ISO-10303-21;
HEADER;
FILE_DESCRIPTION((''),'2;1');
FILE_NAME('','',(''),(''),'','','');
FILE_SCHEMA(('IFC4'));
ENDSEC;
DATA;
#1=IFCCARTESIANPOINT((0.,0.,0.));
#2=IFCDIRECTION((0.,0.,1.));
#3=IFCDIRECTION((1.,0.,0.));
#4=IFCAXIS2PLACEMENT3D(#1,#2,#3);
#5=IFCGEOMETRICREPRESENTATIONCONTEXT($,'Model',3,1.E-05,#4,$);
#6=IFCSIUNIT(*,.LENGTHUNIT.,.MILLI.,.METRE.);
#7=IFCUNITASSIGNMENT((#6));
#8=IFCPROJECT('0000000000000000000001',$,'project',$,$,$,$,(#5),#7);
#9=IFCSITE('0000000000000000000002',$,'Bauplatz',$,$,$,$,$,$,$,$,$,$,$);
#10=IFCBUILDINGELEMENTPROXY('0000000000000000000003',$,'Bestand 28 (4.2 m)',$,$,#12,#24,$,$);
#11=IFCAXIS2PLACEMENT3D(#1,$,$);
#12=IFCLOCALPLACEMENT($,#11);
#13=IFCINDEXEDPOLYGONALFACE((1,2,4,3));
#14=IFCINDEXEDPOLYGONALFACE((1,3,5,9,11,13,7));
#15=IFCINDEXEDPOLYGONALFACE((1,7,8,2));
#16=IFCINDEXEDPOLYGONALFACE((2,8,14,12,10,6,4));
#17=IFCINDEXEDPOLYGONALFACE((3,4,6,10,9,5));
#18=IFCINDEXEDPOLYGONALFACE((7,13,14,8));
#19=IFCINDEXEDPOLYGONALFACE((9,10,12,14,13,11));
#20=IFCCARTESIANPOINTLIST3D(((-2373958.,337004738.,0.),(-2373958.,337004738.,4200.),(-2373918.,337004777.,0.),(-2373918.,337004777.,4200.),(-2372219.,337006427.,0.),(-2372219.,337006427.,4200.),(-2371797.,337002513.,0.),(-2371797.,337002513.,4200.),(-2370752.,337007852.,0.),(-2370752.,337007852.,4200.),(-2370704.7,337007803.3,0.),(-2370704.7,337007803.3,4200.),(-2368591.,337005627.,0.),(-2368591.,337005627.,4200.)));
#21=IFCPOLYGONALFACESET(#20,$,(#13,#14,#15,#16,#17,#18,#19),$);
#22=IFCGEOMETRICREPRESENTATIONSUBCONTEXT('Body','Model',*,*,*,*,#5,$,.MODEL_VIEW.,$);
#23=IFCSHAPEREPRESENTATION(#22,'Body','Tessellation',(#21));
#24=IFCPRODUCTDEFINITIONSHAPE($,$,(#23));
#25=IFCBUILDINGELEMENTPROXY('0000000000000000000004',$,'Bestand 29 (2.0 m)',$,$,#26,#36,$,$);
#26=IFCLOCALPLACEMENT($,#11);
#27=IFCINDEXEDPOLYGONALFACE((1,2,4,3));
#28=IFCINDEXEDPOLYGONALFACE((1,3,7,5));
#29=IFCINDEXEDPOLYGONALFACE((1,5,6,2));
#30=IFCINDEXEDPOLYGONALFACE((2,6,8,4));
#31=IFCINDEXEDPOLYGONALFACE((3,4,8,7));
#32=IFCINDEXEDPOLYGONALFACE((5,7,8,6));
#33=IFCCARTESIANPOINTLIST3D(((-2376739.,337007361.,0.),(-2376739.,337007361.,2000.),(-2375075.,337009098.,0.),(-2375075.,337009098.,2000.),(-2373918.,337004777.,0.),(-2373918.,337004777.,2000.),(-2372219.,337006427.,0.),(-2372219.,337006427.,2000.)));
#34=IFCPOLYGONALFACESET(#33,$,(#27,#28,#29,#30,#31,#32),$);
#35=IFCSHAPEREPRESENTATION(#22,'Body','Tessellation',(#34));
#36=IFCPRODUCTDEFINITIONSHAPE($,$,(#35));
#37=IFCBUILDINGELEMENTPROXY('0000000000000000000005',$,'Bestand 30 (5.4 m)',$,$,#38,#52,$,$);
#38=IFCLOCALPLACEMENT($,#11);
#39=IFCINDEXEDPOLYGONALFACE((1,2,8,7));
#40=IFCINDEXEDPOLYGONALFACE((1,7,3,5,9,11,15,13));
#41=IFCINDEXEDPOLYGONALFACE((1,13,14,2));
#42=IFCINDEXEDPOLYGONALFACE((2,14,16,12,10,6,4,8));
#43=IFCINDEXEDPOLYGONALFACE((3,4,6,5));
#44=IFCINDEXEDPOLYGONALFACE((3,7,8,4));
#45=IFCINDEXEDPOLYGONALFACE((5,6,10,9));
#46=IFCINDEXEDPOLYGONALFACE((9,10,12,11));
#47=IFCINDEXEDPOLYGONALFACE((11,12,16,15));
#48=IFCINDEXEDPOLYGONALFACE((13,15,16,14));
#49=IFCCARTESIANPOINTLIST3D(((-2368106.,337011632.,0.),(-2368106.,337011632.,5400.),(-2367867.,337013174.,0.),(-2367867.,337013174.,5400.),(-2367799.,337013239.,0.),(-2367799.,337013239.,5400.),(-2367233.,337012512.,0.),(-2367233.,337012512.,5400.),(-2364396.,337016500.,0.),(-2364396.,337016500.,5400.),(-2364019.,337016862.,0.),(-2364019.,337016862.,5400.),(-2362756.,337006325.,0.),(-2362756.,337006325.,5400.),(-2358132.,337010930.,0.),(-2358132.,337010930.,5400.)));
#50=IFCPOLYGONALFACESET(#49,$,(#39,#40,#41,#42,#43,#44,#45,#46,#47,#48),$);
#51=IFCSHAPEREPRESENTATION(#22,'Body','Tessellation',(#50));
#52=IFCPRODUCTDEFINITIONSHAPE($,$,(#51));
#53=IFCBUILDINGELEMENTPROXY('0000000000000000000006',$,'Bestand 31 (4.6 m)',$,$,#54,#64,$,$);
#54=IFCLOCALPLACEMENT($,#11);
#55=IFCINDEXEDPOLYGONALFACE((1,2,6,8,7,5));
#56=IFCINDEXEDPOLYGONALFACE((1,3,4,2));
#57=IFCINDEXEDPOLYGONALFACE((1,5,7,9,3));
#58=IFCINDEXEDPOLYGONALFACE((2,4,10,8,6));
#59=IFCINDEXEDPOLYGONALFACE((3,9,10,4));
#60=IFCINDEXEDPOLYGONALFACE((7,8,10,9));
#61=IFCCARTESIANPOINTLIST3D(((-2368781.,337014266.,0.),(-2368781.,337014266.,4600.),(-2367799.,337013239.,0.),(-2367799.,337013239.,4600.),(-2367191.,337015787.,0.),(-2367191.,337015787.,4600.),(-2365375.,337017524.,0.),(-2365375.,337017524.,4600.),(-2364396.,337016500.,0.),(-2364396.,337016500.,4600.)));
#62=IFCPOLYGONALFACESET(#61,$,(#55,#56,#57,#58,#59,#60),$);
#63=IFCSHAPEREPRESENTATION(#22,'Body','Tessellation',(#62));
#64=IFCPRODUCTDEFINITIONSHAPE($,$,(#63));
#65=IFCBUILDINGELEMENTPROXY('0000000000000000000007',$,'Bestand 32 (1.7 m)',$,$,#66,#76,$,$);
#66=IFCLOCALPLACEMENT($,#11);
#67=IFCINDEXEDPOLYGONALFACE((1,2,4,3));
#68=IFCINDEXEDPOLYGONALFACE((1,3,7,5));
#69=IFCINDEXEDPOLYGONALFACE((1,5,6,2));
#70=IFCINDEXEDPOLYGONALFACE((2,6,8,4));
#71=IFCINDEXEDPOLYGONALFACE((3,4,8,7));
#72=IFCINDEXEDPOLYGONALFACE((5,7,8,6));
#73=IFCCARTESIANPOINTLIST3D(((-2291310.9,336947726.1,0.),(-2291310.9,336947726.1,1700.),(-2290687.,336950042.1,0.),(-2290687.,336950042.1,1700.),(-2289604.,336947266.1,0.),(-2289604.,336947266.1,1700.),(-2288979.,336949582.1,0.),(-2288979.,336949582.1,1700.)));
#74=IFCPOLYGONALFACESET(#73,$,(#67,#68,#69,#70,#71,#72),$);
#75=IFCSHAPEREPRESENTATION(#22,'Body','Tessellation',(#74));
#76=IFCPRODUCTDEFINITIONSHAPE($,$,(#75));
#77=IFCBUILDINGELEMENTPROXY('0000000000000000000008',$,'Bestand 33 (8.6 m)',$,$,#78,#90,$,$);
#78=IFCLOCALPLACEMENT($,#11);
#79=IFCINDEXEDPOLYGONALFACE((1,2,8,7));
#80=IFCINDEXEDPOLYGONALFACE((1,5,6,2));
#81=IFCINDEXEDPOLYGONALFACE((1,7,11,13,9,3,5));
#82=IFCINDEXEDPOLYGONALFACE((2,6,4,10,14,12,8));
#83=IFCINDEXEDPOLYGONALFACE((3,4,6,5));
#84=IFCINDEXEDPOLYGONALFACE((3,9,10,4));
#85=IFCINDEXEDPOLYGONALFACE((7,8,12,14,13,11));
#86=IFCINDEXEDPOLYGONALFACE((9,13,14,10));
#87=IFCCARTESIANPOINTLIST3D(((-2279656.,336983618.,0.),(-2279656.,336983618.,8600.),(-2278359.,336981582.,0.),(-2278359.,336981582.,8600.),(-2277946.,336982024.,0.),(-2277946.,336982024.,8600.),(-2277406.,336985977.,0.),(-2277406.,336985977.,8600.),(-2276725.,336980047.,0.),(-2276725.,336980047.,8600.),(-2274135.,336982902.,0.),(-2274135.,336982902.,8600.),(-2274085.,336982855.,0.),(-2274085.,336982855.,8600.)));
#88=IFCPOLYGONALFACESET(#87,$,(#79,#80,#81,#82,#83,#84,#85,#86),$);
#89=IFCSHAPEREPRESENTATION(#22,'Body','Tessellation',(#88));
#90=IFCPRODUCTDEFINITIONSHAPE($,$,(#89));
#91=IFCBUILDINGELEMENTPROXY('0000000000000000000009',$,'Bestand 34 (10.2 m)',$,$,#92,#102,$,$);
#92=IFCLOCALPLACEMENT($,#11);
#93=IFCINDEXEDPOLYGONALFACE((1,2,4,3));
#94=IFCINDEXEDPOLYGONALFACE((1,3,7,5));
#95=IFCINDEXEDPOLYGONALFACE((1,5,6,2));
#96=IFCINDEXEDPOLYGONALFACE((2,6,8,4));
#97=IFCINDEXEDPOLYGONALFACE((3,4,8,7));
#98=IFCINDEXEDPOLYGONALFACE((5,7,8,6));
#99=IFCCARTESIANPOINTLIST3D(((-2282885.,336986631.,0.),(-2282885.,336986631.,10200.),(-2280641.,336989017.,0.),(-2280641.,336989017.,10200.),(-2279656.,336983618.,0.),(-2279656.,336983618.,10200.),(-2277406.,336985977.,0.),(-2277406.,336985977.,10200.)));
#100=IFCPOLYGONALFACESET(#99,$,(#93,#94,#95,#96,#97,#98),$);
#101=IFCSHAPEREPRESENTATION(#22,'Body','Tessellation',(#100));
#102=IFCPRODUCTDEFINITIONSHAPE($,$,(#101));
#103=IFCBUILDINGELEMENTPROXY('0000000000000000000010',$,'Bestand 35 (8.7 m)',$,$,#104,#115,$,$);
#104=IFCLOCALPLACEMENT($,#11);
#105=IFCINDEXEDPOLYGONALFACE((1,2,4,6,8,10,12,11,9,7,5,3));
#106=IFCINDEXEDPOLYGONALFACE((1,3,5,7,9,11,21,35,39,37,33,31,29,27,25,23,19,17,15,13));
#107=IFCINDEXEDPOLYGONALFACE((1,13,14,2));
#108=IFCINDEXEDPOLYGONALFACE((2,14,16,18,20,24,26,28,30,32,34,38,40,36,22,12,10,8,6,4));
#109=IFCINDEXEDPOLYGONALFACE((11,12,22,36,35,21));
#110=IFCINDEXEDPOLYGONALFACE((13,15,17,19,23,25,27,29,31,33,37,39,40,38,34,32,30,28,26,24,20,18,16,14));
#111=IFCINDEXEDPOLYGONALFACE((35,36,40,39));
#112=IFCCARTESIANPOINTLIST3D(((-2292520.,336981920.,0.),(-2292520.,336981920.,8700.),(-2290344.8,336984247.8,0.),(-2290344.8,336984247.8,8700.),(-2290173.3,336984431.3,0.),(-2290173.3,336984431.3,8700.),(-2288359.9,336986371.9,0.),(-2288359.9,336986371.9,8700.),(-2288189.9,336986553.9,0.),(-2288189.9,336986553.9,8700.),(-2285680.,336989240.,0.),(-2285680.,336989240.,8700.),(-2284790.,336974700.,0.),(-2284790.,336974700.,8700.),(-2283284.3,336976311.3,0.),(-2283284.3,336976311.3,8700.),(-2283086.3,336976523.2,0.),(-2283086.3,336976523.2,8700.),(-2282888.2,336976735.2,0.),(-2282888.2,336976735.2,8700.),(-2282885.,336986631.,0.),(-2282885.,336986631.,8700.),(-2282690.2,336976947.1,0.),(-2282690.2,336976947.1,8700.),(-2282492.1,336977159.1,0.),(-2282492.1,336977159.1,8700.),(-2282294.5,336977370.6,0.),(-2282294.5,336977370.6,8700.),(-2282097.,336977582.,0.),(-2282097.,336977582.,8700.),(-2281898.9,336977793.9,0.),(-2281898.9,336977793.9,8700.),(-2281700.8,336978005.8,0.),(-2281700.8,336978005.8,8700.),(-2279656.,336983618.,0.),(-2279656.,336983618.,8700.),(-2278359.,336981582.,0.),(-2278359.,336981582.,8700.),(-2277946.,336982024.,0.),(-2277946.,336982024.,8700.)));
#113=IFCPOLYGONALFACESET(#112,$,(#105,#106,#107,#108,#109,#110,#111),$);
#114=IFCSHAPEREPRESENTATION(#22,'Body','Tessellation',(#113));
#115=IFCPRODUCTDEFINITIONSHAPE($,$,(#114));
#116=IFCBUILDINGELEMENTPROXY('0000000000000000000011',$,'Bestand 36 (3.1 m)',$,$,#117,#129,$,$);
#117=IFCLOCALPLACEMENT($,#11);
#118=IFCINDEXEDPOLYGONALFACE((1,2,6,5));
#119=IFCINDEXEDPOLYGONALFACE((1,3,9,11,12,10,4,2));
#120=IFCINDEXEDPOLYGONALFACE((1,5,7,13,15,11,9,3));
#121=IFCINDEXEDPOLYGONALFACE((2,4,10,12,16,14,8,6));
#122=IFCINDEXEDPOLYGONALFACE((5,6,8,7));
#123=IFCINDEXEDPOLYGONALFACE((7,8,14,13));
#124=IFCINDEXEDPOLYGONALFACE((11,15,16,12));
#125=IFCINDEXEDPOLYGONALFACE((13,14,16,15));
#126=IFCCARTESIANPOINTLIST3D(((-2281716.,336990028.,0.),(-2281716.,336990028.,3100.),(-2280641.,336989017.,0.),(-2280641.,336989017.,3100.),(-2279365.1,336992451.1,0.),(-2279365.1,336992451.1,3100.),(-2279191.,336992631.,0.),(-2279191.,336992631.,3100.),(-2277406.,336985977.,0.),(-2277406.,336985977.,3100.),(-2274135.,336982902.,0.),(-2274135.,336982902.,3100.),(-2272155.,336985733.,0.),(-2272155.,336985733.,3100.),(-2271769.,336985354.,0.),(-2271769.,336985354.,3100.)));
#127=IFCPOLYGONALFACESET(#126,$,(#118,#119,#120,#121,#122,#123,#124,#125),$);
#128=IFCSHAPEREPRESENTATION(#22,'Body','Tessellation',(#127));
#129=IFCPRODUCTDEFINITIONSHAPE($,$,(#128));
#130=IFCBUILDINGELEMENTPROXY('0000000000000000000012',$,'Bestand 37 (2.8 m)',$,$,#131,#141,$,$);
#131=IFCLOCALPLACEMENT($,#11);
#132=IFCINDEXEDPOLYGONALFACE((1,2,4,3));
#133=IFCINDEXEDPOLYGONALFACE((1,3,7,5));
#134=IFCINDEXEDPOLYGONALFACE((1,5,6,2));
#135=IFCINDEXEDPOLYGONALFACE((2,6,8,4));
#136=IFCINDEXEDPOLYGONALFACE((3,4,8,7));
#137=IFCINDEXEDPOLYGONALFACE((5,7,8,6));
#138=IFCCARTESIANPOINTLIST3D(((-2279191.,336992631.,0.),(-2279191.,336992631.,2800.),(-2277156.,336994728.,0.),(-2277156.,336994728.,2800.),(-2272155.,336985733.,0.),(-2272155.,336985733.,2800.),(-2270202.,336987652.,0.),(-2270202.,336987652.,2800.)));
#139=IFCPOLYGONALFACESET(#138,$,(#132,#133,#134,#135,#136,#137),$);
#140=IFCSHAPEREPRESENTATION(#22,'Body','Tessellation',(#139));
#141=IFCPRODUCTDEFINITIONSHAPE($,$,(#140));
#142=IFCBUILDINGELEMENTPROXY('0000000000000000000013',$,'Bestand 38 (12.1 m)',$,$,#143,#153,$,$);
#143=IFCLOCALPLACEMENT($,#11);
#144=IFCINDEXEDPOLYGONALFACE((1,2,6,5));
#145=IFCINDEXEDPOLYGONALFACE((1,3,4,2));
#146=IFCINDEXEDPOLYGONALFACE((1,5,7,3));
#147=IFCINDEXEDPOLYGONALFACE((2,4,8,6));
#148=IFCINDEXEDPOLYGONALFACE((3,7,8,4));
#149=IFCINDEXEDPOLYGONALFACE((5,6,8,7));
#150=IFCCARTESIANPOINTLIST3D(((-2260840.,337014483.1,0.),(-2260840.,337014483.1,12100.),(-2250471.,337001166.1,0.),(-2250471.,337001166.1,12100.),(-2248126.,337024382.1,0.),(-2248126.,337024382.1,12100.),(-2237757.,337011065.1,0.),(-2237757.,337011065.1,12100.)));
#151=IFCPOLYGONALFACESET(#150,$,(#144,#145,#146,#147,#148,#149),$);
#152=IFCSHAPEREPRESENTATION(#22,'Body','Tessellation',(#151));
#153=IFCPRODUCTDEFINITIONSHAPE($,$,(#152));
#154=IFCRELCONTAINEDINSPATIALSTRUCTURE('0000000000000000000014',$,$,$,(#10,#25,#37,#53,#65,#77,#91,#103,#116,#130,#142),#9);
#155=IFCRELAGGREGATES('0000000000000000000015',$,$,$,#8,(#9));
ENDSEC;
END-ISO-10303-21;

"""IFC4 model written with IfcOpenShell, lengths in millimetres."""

from ifc_helpers import new_model, si_unit, origin_with_axes, place, context, subcontext, project, spatial, indexed_curve, outline, extrude, element, save


model = new_model("IFC4")

# Units and contexts
model_context = context("Model", 3, precision=1e-05, world=origin_with_axes())
body_context = subcontext(model_context, "Body", "Model", "MODEL_VIEW")
ifc_project = project(units=[si_unit("LENGTHUNIT", "METRE", prefix="MILLI")], contexts=[model_context])

# Site
site = spatial("IfcSite", under=ifc_project, Name="Bauplatz")

# Building element proxies
proxy_1_placement = place(None, origin_with_axes())
element("IfcBuildingElementProxy", 1, at=proxy_1_placement, inside=site, Name="Bestand 28 (4.2 m)", context=body_context, shape_type="SweptSolid", body=[
    extrude(outline(indexed_curve([(-2370704.7, 337007803.3), (-2370752.0, 337007852.0), (-2372219.0, 337006427.0), (-2373918.0, 337004777.0), (-2373958.0, 337004738.0), (-2371797.0, 337002513.0), (-2368591.0, 337005627.0)])), None, (0.0, 0.0, 1.0), 4200.0),
])
proxy_2_placement = place(None, origin_with_axes())
element("IfcBuildingElementProxy", 2, at=proxy_2_placement, inside=site, Name="Bestand 29 (2.0 m)", context=body_context, shape_type="SweptSolid", body=[
    extrude(outline(indexed_curve([(-2372219.0, 337006427.0), (-2375075.0, 337009098.0), (-2376739.0, 337007361.0), (-2373918.0, 337004777.0)])), None, (0.0, 0.0, 1.0), 2000.0),
])
proxy_3_placement = place(None, origin_with_axes())
element("IfcBuildingElementProxy", 3, at=proxy_3_placement, inside=site, Name="Bestand 30 (5.4 m)", context=body_context, shape_type="SweptSolid", body=[
    extrude(outline(indexed_curve([(-2358132.0, 337010930.0), (-2364019.0, 337016862.0), (-2364396.0, 337016500.0), (-2367799.0, 337013239.0), (-2367867.0, 337013174.0), (-2367233.0, 337012512.0), (-2368106.0, 337011632.0), (-2362756.0, 337006325.0)])), None, (0.0, 0.0, 1.0), 5400.0),
])
proxy_4_placement = place(None, origin_with_axes())
element("IfcBuildingElementProxy", 4, at=proxy_4_placement, inside=site, Name="Bestand 31 (4.6 m)", context=body_context, shape_type="SweptSolid", body=[
    extrude(outline(indexed_curve([(-2364396.0, 337016500.0), (-2365375.0, 337017524.0), (-2367191.0, 337015787.0), (-2368781.0, 337014266.0), (-2367799.0, 337013239.0)])), None, (0.0, 0.0, 1.0), 4600.0),
])
proxy_5_placement = place(None, origin_with_axes())
element("IfcBuildingElementProxy", 5, at=proxy_5_placement, inside=site, Name="Bestand 32 (1.7 m)", context=body_context, shape_type="SweptSolid", body=[
    extrude(outline(indexed_curve([(-2288979.0, 336949582.1), (-2290687.0, 336950042.1), (-2291310.9, 336947726.1), (-2289604.0, 336947266.1)])), None, (0.0, 0.0, 1.0), 1700.0),
])
proxy_6_placement = place(None, origin_with_axes())
element("IfcBuildingElementProxy", 6, at=proxy_6_placement, inside=site, Name="Bestand 33 (8.6 m)", context=body_context, shape_type="SweptSolid", body=[
    extrude(outline(indexed_curve([(-2274135.0, 336982902.0), (-2277406.0, 336985977.0), (-2279656.0, 336983618.0), (-2277946.0, 336982024.0), (-2278359.0, 336981582.0), (-2276725.0, 336980047.0), (-2274085.0, 336982855.0)])), None, (0.0, 0.0, 1.0), 8600.0),
])
proxy_7_placement = place(None, origin_with_axes())
element("IfcBuildingElementProxy", 7, at=proxy_7_placement, inside=site, Name="Bestand 34 (10.2 m)", context=body_context, shape_type="SweptSolid", body=[
    extrude(outline(indexed_curve([(-2277406.0, 336985977.0), (-2280641.0, 336989017.0), (-2282885.0, 336986631.0), (-2279656.0, 336983618.0)])), None, (0.0, 0.0, 1.0), 10200.0),
])
proxy_8_placement = place(None, origin_with_axes())
element("IfcBuildingElementProxy", 8, at=proxy_8_placement, inside=site, Name="Bestand 35 (8.7 m)", context=body_context, shape_type="SweptSolid", body=[
    extrude(outline(indexed_curve([(-2282885.0, 336986631.0), (-2285680.0, 336989240.0), (-2288189.9, 336986553.9), (-2288359.9, 336986371.9), (-2290173.3, 336984431.3), (-2290344.8, 336984247.8), (-2292520.0, 336981920.0), (-2284790.0, 336974700.0), (-2283284.3, 336976311.3), (-2283086.3, 336976523.2), (-2282888.2, 336976735.2), (-2282690.2, 336976947.1), (-2282492.1, 336977159.1), (-2282294.5, 336977370.6), (-2282097.0, 336977582.0), (-2281898.9, 336977793.9), (-2281700.8, 336978005.8), (-2278359.0, 336981582.0), (-2277946.0, 336982024.0), (-2279656.0, 336983618.0)])), None, (0.0, 0.0, 1.0), 8700.0),
])
proxy_9_placement = place(None, origin_with_axes())
element("IfcBuildingElementProxy", 9, at=proxy_9_placement, inside=site, Name="Bestand 36 (3.1 m)", context=body_context, shape_type="SweptSolid", body=[
    extrude(outline(indexed_curve([(-2272155.0, 336985733.0), (-2279191.0, 336992631.0), (-2279365.1, 336992451.1), (-2281716.0, 336990028.0), (-2280641.0, 336989017.0), (-2277406.0, 336985977.0), (-2274135.0, 336982902.0), (-2271769.0, 336985354.0)])), None, (0.0, 0.0, 1.0), 3100.0),
])
proxy_10_placement = place(None, origin_with_axes())
element("IfcBuildingElementProxy", 10, at=proxy_10_placement, inside=site, Name="Bestand 37 (2.8 m)", context=body_context, shape_type="SweptSolid", body=[
    extrude(outline(indexed_curve([(-2270202.0, 336987652.0), (-2277156.0, 336994728.0), (-2279191.0, 336992631.0), (-2272155.0, 336985733.0)])), None, (0.0, 0.0, 1.0), 2800.0),
])
proxy_11_placement = place(None, origin_with_axes())
element("IfcBuildingElementProxy", 11, at=proxy_11_placement, inside=site, Name="Bestand 38 (12.1 m)", context=body_context, shape_type="SweptSolid", body=[
    extrude(outline(indexed_curve([(-2237757.0, 337011065.1), (-2248126.0, 337024382.1), (-2260840.0, 337014483.1), (-2250471.0, 337001166.1)])), None, (0.0, 0.0, 1.0), 12100.0),
])

save(model, "model.ifc")
